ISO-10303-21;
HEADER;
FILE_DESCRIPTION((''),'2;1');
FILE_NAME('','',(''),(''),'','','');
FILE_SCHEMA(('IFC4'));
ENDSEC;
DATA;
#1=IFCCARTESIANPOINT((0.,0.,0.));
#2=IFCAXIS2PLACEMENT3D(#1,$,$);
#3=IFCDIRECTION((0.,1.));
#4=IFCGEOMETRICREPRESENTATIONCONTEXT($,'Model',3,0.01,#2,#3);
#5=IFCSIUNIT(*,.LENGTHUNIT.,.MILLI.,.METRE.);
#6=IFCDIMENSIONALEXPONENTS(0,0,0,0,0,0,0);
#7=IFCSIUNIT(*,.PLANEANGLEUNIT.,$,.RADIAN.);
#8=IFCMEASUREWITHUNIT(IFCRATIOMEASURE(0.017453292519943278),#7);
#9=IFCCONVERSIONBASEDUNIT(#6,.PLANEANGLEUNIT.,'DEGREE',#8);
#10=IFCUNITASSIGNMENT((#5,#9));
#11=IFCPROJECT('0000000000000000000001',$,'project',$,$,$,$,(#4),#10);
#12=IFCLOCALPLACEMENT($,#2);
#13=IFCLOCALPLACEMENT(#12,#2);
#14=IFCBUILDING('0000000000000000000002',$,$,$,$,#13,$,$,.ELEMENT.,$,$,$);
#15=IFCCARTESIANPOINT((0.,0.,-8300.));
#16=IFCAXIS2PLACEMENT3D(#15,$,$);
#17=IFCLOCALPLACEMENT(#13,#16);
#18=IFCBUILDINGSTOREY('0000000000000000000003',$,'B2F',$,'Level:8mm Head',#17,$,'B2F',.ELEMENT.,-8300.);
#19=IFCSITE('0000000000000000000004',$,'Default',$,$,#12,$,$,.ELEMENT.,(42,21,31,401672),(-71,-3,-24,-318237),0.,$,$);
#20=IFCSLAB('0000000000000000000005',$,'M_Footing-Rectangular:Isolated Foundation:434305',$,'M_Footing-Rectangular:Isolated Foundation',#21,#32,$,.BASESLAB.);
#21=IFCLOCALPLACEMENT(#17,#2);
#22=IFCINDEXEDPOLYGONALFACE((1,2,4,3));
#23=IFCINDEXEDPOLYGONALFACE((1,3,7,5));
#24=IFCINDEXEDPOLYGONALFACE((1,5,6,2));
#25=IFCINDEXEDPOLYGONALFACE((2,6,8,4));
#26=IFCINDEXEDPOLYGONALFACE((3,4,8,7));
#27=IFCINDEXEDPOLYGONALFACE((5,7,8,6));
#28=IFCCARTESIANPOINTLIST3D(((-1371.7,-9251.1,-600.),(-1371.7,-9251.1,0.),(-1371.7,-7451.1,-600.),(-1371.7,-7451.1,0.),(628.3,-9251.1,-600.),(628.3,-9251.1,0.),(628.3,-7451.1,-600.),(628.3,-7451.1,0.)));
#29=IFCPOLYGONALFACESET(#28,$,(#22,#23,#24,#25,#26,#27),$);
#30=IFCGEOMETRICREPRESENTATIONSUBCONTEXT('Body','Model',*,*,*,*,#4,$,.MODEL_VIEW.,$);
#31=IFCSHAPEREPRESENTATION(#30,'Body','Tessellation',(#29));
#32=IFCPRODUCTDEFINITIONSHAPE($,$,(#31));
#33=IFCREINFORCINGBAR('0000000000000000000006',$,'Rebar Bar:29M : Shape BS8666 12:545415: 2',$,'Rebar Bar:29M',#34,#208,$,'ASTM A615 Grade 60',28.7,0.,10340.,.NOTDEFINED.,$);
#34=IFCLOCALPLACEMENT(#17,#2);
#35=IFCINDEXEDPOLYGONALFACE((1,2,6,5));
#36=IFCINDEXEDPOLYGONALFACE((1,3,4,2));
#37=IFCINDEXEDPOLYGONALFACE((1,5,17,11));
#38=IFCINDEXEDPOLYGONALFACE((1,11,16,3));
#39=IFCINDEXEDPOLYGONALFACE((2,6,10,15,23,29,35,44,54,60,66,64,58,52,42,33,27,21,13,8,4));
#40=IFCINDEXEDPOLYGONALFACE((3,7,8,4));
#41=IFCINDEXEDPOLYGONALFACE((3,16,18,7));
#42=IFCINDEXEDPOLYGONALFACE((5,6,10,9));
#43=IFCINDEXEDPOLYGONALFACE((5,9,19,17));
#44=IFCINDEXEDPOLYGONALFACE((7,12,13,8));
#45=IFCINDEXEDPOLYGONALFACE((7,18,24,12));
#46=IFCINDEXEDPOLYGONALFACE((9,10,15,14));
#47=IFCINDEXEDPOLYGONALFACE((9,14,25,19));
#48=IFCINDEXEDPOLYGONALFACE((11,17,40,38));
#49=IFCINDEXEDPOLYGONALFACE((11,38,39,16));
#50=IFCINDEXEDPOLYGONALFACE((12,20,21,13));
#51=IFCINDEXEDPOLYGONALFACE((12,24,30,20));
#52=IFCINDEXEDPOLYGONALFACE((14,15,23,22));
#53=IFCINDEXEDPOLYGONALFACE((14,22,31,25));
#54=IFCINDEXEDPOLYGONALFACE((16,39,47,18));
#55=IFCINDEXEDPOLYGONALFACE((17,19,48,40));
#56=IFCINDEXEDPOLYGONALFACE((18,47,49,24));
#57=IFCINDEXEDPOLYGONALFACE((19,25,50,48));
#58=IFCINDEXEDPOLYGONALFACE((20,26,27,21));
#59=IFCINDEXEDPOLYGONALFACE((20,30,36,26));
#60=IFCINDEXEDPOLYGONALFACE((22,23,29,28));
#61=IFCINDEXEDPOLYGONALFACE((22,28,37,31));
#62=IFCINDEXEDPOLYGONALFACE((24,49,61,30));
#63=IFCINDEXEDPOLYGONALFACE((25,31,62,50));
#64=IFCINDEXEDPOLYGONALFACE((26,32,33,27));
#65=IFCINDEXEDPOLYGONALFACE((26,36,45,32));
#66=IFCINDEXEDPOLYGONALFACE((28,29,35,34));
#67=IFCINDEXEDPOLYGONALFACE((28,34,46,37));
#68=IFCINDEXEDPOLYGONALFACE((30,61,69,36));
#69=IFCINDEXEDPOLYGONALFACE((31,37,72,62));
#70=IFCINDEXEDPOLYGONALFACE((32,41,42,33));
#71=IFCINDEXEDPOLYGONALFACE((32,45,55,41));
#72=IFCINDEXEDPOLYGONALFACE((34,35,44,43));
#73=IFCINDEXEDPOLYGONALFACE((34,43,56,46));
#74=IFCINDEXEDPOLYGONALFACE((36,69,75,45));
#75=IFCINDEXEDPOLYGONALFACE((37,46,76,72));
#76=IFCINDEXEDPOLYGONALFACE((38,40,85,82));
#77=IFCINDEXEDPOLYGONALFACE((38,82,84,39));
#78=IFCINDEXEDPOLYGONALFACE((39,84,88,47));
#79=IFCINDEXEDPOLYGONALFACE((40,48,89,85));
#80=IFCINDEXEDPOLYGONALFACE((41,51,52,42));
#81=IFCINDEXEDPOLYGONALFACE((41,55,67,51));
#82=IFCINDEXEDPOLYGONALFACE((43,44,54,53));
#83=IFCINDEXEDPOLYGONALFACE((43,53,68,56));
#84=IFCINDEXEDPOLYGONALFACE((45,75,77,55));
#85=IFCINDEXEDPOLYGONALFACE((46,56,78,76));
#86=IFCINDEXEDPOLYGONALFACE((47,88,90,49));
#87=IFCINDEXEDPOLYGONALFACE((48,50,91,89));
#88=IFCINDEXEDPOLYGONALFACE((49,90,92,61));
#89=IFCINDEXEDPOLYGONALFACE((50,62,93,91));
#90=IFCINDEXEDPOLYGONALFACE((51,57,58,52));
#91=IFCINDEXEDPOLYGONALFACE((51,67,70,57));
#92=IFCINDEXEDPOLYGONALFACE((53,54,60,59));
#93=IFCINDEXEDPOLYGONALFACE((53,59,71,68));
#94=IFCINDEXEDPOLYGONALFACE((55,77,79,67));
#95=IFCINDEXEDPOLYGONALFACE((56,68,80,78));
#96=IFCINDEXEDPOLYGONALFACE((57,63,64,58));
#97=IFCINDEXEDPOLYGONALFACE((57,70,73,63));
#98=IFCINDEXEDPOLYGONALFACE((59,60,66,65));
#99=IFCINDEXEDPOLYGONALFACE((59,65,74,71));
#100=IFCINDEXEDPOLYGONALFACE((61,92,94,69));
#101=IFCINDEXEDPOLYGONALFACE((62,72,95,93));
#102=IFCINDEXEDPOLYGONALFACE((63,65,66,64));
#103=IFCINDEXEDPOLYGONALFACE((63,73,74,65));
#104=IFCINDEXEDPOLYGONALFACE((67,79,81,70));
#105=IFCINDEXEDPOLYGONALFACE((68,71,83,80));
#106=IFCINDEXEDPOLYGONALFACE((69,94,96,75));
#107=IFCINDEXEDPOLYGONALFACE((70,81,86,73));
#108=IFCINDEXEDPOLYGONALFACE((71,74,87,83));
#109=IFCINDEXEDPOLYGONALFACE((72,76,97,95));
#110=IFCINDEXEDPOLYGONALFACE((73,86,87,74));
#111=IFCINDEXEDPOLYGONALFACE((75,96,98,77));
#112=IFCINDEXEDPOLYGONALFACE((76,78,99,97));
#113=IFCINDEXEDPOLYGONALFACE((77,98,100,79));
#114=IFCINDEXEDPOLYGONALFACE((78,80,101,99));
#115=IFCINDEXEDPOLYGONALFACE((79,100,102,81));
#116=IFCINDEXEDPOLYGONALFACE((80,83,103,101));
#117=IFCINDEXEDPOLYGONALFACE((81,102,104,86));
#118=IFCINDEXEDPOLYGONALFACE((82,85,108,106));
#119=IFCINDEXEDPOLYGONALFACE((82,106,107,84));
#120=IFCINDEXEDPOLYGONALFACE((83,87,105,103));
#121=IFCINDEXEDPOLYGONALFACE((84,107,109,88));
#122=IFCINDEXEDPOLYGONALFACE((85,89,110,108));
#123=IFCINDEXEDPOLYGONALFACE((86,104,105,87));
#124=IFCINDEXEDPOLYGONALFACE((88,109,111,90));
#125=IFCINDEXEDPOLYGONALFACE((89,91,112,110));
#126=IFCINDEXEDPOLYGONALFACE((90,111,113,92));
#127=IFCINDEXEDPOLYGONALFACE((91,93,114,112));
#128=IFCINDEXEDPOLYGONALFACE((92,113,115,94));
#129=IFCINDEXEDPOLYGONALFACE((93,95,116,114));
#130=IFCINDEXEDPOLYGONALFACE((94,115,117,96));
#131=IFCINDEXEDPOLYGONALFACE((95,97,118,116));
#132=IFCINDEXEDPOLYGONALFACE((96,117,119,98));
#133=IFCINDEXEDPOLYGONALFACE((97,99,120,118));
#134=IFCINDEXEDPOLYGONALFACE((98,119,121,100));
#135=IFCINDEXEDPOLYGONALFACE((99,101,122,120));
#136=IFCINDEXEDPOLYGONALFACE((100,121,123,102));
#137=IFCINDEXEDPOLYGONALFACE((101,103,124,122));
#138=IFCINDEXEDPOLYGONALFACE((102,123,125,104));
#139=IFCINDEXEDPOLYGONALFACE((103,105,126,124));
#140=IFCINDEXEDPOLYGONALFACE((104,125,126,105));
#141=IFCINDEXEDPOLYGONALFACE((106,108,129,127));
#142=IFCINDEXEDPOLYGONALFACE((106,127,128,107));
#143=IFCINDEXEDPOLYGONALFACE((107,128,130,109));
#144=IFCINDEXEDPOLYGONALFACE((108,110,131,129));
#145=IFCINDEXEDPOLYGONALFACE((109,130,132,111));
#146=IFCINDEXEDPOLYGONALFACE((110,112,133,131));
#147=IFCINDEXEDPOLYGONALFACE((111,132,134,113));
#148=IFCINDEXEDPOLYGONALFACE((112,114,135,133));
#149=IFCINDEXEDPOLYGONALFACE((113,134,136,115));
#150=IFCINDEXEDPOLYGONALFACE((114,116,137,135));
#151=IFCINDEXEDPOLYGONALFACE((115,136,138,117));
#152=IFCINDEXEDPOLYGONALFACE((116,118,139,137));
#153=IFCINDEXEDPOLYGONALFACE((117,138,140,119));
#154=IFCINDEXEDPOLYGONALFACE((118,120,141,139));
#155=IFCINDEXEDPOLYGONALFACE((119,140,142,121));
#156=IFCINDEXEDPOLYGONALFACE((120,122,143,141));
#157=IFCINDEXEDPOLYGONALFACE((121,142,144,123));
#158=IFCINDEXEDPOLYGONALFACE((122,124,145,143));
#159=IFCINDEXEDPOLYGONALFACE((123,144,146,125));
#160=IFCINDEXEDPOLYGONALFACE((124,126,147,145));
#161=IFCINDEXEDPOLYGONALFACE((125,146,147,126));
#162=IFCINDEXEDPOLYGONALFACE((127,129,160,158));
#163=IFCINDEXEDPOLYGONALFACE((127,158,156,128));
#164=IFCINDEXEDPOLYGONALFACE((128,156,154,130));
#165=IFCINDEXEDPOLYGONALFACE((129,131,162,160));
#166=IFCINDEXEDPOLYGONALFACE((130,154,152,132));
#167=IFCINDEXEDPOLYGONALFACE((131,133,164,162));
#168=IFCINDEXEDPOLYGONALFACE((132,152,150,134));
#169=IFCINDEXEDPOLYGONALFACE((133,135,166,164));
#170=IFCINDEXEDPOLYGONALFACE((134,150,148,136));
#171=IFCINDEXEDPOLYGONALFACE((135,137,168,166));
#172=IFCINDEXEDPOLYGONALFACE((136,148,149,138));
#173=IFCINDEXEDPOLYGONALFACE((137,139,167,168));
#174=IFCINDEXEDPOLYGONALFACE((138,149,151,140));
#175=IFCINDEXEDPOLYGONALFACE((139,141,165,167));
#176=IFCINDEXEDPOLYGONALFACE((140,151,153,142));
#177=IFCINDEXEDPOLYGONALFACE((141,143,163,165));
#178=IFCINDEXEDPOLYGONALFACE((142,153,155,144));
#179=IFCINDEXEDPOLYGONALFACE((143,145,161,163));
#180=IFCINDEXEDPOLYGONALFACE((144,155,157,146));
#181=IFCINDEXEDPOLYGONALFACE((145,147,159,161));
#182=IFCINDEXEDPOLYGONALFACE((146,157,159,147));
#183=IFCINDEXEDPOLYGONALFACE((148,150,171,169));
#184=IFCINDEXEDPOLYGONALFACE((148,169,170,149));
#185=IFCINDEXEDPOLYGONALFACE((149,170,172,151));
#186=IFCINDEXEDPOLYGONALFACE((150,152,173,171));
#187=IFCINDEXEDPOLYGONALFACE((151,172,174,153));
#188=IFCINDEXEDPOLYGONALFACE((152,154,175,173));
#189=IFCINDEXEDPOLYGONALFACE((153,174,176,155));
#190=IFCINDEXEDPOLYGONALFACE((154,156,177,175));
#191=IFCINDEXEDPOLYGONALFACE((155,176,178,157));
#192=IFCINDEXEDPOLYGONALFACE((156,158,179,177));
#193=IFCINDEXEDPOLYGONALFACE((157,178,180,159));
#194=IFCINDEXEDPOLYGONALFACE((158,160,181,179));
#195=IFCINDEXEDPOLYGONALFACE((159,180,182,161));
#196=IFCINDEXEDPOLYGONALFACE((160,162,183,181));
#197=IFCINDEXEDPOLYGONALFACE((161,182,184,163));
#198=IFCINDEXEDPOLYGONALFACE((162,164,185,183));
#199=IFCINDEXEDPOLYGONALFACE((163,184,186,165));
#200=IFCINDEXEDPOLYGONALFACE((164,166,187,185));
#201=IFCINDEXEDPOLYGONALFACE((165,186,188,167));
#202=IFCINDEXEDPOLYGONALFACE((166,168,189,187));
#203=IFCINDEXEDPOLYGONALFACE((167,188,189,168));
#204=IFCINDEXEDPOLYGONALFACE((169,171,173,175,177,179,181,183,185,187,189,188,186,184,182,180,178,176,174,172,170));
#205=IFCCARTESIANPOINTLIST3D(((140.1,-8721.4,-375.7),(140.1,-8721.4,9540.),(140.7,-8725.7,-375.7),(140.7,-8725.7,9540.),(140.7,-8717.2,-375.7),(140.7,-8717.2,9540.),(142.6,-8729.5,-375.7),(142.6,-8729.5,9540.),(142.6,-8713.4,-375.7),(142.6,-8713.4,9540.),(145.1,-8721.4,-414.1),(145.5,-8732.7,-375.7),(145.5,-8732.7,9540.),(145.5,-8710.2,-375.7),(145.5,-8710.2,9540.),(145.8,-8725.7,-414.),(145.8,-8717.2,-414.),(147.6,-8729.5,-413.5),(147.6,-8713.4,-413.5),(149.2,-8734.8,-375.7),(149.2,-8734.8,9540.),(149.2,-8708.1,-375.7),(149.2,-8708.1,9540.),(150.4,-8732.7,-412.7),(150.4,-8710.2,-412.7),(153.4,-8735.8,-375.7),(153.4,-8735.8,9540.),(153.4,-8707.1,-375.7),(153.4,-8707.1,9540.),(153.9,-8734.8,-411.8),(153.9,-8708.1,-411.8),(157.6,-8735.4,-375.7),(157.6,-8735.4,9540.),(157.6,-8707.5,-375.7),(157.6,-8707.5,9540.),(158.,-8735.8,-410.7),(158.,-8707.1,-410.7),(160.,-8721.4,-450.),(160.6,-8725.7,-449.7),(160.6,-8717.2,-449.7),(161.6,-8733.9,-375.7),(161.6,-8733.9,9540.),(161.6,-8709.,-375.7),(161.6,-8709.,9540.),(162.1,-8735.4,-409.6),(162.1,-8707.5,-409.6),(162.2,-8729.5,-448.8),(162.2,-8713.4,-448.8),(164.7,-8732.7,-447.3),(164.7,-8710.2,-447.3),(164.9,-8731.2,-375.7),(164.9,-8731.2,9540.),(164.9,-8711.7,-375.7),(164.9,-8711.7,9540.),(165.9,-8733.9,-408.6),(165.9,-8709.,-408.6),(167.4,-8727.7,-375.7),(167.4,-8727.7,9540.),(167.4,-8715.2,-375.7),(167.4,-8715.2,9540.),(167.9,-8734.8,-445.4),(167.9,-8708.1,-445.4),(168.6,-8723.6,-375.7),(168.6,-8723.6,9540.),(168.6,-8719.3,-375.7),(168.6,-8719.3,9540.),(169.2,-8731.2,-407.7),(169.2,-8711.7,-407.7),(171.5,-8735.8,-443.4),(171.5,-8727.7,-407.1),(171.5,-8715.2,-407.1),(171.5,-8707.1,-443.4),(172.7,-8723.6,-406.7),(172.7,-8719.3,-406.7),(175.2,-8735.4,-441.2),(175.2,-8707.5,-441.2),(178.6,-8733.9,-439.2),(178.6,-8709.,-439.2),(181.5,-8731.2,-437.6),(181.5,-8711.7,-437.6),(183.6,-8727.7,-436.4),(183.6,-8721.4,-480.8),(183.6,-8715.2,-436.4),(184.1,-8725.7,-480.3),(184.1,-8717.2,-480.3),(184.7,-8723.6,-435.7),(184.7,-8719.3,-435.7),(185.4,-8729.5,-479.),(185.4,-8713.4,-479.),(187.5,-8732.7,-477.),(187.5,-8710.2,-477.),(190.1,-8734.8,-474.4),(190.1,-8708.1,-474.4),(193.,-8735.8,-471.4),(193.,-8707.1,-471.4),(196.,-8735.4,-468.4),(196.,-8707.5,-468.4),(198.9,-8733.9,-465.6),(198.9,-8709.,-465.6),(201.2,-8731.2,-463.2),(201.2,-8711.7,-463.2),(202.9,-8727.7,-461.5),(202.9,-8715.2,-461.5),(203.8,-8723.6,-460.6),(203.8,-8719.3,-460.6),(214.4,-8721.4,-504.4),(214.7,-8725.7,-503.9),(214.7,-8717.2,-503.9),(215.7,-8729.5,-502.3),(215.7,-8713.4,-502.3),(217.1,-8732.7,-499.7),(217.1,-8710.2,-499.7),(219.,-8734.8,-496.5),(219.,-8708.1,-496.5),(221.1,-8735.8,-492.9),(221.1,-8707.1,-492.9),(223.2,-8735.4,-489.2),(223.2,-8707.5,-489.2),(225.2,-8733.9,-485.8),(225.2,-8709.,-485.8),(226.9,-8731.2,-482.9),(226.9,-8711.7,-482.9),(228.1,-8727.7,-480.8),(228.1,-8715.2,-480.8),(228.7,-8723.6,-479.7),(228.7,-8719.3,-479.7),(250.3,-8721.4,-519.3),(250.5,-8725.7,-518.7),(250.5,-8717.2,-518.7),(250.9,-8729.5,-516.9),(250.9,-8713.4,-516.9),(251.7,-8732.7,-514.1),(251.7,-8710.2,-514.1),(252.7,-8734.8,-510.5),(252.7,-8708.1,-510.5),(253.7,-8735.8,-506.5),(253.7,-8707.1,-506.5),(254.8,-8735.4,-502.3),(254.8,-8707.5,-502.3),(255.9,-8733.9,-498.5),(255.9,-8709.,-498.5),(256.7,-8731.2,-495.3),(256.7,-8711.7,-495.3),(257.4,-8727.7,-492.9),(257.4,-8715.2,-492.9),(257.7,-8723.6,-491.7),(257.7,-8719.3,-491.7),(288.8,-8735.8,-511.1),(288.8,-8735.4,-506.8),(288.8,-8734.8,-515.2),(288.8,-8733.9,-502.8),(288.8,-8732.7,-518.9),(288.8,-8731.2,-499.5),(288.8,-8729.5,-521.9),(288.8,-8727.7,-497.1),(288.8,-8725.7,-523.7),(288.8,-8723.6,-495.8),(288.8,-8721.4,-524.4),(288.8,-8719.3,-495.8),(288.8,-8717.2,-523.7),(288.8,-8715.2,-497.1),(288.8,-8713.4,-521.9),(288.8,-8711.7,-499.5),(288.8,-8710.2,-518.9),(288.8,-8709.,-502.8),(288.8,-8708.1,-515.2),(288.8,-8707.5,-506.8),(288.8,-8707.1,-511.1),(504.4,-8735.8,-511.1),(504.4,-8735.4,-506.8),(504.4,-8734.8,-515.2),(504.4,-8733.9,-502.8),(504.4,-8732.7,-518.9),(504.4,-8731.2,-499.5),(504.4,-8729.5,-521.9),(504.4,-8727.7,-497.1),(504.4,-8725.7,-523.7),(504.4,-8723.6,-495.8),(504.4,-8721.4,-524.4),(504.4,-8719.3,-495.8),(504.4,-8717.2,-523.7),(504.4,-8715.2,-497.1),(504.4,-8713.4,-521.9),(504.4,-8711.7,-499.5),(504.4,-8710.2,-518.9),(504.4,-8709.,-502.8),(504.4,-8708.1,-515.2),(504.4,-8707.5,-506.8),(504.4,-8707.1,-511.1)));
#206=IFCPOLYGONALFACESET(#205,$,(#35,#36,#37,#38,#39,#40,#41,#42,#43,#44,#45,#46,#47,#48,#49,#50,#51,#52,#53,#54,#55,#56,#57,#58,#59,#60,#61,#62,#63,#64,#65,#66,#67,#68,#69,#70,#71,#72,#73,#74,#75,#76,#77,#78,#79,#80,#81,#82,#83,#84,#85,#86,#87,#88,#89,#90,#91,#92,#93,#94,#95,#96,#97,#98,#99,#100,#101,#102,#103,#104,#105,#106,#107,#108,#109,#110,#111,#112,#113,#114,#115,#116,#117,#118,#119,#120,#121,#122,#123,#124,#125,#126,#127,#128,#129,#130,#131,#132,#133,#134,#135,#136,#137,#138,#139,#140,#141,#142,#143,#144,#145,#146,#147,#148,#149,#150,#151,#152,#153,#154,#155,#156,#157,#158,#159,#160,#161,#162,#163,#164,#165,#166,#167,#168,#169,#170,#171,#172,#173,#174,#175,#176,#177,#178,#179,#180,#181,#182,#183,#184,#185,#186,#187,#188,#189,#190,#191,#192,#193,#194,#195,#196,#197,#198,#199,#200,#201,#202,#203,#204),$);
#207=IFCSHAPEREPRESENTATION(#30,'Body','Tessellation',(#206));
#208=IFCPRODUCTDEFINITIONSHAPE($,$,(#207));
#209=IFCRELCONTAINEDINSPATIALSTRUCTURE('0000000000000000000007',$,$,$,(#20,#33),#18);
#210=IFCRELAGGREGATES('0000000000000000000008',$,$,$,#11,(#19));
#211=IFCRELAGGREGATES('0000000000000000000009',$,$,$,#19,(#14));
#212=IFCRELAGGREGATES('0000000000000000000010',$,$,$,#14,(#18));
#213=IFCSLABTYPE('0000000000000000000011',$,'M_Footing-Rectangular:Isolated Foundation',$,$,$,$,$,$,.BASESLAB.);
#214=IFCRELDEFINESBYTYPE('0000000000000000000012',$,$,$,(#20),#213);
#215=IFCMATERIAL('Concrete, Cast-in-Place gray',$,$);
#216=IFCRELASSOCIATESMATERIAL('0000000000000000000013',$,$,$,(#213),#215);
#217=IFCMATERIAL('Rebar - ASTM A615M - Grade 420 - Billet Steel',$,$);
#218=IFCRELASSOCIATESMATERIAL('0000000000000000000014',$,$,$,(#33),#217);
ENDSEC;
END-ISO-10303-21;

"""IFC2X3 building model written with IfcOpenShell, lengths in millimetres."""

from ifc_helpers import new_model, entity, si_unit, converted_unit, direction, frame, origin, origin_2d_with_axis, place, context, subcontext, project, spatial, rectangle, extrude, material, type_object, element, save


model = new_model("IFC2X3")

# Units and contexts
model_context = context("Model", 3, precision=0.01, world=origin(), true_north=direction((0.0, 1.0)))
body_context = subcontext(model_context, "Body", "Model", "MODEL_VIEW")
ifc_project = project(units=[si_unit("LENGTHUNIT", "METRE", prefix="MILLI"), converted_unit("PLANEANGLEUNIT", "DEGREE", entity("IfcRatioMeasure", 0.017453292519943278), si_unit("PLANEANGLEUNIT", "RADIAN"), dimensions=[0, 0, 0, 0, 0, 0, 0])], contexts=[model_context])

# Site, building, storey
site_placement = place(None, origin())
site = spatial("IfcSite", under=ifc_project, at=site_placement, Name="Default", CompositionType="ELEMENT", RefLatitude=(42, 21, 31, 401672), RefLongitude=(-71, -3, -24, -318237), RefElevation=0.0)
building_placement = place(site_placement, origin())
building = spatial("IfcBuilding", under=site, at=building_placement, CompositionType="ELEMENT")
storey_placement = place(building_placement, frame((0.0, 0.0, -8300.0)))
storey = spatial("IfcBuildingStorey", under=building, at=storey_placement, Name="B2F", ObjectType="Level:8mm Head", LongName="B2F", CompositionType="ELEMENT", Elevation=-8300.0)

# Shared definitions
ifc_material_1 = material(Name="Concrete, Cast-in-Place gray")

# Slab
slab_type = type_object("IfcSlabType", Name="M_Footing-Rectangular:Isolated Foundation", PredefinedType="BASESLAB", material=ifc_material_1)
slab_placement = place(storey_placement, origin())
element("IfcSlab", 1, at=slab_placement, inside=storey, type_object=slab_type, Name="M_Footing-Rectangular:Isolated Foundation:434305", ObjectType="M_Footing-Rectangular:Isolated Foundation", PredefinedType="BASESLAB", context=body_context, shape_type="SweptSolid", body=[
    extrude(rectangle(XDim=2000.0, YDim=1800.0, at=origin_2d_with_axis()), frame((-371.7, -8351.1, -600.0), z_axis=(0.0, 0.0, 1.0), x_axis=(-1.0, 0.0, 0.0)), (0.0, 0.0, 1.0), 600.0),
])

# Reinforcing bar
ifc_material_2 = material(Name="Rebar - ASTM A615M - Grade 420 - Billet Steel")
reinforcing_bar_1_placement = place(storey_placement, origin())
element("IfcReinforcingBar", 2, at=reinforcing_bar_1_placement, inside=storey, material=ifc_material_2, Name="Rebar Bar:29M : Shape BS8666 12:545415: 2", SteelGrade="ASTM A615 Grade 60", ObjectType="Rebar Bar:29M", BarLength=10340.0, BarRole="NOTDEFINED", CrossSectionArea=0.0, NominalDiameter=28.7, context=body_context, shape_type="AdvancedSweptSolid", body=[
    entity("IfcSweptDiskSolid", entity("IfcCompositeCurve", [entity("IfcCompositeCurveSegment", "CONTINUOUS", True, entity("IfcPolyline", [entity("IfcCartesianPoint", [154.4, -8721.4, 9540.0]), entity("IfcCartesianPoint", [154.4, -8721.4, -375.7])])), entity("IfcCompositeCurveSegment", "CONTINUOUS", True, entity("IfcTrimmedCurve", entity("IfcCircle", entity("IfcAxis2Placement3D", entity("IfcCartesianPoint", [288.8, -8721.4, -375.7]), entity("IfcDirection", [0.0, -1.0, 0.0]), entity("IfcDirection", [0.0, 0.0, -1.0])), 134.3), [entity("IfcParameterValue", 270.0)], [entity("IfcParameterValue", 360.0)], True, "PARAMETER")), entity("IfcCompositeCurveSegment", "CONTINUOUS", True, entity("IfcPolyline", [entity("IfcCartesianPoint", [288.8, -8721.4, -510.0]), entity("IfcCartesianPoint", [504.4, -8721.4, -510.0])]))], False), 14.3, None, 0.0, 92.0),
])

save(model, "model.ifc")
